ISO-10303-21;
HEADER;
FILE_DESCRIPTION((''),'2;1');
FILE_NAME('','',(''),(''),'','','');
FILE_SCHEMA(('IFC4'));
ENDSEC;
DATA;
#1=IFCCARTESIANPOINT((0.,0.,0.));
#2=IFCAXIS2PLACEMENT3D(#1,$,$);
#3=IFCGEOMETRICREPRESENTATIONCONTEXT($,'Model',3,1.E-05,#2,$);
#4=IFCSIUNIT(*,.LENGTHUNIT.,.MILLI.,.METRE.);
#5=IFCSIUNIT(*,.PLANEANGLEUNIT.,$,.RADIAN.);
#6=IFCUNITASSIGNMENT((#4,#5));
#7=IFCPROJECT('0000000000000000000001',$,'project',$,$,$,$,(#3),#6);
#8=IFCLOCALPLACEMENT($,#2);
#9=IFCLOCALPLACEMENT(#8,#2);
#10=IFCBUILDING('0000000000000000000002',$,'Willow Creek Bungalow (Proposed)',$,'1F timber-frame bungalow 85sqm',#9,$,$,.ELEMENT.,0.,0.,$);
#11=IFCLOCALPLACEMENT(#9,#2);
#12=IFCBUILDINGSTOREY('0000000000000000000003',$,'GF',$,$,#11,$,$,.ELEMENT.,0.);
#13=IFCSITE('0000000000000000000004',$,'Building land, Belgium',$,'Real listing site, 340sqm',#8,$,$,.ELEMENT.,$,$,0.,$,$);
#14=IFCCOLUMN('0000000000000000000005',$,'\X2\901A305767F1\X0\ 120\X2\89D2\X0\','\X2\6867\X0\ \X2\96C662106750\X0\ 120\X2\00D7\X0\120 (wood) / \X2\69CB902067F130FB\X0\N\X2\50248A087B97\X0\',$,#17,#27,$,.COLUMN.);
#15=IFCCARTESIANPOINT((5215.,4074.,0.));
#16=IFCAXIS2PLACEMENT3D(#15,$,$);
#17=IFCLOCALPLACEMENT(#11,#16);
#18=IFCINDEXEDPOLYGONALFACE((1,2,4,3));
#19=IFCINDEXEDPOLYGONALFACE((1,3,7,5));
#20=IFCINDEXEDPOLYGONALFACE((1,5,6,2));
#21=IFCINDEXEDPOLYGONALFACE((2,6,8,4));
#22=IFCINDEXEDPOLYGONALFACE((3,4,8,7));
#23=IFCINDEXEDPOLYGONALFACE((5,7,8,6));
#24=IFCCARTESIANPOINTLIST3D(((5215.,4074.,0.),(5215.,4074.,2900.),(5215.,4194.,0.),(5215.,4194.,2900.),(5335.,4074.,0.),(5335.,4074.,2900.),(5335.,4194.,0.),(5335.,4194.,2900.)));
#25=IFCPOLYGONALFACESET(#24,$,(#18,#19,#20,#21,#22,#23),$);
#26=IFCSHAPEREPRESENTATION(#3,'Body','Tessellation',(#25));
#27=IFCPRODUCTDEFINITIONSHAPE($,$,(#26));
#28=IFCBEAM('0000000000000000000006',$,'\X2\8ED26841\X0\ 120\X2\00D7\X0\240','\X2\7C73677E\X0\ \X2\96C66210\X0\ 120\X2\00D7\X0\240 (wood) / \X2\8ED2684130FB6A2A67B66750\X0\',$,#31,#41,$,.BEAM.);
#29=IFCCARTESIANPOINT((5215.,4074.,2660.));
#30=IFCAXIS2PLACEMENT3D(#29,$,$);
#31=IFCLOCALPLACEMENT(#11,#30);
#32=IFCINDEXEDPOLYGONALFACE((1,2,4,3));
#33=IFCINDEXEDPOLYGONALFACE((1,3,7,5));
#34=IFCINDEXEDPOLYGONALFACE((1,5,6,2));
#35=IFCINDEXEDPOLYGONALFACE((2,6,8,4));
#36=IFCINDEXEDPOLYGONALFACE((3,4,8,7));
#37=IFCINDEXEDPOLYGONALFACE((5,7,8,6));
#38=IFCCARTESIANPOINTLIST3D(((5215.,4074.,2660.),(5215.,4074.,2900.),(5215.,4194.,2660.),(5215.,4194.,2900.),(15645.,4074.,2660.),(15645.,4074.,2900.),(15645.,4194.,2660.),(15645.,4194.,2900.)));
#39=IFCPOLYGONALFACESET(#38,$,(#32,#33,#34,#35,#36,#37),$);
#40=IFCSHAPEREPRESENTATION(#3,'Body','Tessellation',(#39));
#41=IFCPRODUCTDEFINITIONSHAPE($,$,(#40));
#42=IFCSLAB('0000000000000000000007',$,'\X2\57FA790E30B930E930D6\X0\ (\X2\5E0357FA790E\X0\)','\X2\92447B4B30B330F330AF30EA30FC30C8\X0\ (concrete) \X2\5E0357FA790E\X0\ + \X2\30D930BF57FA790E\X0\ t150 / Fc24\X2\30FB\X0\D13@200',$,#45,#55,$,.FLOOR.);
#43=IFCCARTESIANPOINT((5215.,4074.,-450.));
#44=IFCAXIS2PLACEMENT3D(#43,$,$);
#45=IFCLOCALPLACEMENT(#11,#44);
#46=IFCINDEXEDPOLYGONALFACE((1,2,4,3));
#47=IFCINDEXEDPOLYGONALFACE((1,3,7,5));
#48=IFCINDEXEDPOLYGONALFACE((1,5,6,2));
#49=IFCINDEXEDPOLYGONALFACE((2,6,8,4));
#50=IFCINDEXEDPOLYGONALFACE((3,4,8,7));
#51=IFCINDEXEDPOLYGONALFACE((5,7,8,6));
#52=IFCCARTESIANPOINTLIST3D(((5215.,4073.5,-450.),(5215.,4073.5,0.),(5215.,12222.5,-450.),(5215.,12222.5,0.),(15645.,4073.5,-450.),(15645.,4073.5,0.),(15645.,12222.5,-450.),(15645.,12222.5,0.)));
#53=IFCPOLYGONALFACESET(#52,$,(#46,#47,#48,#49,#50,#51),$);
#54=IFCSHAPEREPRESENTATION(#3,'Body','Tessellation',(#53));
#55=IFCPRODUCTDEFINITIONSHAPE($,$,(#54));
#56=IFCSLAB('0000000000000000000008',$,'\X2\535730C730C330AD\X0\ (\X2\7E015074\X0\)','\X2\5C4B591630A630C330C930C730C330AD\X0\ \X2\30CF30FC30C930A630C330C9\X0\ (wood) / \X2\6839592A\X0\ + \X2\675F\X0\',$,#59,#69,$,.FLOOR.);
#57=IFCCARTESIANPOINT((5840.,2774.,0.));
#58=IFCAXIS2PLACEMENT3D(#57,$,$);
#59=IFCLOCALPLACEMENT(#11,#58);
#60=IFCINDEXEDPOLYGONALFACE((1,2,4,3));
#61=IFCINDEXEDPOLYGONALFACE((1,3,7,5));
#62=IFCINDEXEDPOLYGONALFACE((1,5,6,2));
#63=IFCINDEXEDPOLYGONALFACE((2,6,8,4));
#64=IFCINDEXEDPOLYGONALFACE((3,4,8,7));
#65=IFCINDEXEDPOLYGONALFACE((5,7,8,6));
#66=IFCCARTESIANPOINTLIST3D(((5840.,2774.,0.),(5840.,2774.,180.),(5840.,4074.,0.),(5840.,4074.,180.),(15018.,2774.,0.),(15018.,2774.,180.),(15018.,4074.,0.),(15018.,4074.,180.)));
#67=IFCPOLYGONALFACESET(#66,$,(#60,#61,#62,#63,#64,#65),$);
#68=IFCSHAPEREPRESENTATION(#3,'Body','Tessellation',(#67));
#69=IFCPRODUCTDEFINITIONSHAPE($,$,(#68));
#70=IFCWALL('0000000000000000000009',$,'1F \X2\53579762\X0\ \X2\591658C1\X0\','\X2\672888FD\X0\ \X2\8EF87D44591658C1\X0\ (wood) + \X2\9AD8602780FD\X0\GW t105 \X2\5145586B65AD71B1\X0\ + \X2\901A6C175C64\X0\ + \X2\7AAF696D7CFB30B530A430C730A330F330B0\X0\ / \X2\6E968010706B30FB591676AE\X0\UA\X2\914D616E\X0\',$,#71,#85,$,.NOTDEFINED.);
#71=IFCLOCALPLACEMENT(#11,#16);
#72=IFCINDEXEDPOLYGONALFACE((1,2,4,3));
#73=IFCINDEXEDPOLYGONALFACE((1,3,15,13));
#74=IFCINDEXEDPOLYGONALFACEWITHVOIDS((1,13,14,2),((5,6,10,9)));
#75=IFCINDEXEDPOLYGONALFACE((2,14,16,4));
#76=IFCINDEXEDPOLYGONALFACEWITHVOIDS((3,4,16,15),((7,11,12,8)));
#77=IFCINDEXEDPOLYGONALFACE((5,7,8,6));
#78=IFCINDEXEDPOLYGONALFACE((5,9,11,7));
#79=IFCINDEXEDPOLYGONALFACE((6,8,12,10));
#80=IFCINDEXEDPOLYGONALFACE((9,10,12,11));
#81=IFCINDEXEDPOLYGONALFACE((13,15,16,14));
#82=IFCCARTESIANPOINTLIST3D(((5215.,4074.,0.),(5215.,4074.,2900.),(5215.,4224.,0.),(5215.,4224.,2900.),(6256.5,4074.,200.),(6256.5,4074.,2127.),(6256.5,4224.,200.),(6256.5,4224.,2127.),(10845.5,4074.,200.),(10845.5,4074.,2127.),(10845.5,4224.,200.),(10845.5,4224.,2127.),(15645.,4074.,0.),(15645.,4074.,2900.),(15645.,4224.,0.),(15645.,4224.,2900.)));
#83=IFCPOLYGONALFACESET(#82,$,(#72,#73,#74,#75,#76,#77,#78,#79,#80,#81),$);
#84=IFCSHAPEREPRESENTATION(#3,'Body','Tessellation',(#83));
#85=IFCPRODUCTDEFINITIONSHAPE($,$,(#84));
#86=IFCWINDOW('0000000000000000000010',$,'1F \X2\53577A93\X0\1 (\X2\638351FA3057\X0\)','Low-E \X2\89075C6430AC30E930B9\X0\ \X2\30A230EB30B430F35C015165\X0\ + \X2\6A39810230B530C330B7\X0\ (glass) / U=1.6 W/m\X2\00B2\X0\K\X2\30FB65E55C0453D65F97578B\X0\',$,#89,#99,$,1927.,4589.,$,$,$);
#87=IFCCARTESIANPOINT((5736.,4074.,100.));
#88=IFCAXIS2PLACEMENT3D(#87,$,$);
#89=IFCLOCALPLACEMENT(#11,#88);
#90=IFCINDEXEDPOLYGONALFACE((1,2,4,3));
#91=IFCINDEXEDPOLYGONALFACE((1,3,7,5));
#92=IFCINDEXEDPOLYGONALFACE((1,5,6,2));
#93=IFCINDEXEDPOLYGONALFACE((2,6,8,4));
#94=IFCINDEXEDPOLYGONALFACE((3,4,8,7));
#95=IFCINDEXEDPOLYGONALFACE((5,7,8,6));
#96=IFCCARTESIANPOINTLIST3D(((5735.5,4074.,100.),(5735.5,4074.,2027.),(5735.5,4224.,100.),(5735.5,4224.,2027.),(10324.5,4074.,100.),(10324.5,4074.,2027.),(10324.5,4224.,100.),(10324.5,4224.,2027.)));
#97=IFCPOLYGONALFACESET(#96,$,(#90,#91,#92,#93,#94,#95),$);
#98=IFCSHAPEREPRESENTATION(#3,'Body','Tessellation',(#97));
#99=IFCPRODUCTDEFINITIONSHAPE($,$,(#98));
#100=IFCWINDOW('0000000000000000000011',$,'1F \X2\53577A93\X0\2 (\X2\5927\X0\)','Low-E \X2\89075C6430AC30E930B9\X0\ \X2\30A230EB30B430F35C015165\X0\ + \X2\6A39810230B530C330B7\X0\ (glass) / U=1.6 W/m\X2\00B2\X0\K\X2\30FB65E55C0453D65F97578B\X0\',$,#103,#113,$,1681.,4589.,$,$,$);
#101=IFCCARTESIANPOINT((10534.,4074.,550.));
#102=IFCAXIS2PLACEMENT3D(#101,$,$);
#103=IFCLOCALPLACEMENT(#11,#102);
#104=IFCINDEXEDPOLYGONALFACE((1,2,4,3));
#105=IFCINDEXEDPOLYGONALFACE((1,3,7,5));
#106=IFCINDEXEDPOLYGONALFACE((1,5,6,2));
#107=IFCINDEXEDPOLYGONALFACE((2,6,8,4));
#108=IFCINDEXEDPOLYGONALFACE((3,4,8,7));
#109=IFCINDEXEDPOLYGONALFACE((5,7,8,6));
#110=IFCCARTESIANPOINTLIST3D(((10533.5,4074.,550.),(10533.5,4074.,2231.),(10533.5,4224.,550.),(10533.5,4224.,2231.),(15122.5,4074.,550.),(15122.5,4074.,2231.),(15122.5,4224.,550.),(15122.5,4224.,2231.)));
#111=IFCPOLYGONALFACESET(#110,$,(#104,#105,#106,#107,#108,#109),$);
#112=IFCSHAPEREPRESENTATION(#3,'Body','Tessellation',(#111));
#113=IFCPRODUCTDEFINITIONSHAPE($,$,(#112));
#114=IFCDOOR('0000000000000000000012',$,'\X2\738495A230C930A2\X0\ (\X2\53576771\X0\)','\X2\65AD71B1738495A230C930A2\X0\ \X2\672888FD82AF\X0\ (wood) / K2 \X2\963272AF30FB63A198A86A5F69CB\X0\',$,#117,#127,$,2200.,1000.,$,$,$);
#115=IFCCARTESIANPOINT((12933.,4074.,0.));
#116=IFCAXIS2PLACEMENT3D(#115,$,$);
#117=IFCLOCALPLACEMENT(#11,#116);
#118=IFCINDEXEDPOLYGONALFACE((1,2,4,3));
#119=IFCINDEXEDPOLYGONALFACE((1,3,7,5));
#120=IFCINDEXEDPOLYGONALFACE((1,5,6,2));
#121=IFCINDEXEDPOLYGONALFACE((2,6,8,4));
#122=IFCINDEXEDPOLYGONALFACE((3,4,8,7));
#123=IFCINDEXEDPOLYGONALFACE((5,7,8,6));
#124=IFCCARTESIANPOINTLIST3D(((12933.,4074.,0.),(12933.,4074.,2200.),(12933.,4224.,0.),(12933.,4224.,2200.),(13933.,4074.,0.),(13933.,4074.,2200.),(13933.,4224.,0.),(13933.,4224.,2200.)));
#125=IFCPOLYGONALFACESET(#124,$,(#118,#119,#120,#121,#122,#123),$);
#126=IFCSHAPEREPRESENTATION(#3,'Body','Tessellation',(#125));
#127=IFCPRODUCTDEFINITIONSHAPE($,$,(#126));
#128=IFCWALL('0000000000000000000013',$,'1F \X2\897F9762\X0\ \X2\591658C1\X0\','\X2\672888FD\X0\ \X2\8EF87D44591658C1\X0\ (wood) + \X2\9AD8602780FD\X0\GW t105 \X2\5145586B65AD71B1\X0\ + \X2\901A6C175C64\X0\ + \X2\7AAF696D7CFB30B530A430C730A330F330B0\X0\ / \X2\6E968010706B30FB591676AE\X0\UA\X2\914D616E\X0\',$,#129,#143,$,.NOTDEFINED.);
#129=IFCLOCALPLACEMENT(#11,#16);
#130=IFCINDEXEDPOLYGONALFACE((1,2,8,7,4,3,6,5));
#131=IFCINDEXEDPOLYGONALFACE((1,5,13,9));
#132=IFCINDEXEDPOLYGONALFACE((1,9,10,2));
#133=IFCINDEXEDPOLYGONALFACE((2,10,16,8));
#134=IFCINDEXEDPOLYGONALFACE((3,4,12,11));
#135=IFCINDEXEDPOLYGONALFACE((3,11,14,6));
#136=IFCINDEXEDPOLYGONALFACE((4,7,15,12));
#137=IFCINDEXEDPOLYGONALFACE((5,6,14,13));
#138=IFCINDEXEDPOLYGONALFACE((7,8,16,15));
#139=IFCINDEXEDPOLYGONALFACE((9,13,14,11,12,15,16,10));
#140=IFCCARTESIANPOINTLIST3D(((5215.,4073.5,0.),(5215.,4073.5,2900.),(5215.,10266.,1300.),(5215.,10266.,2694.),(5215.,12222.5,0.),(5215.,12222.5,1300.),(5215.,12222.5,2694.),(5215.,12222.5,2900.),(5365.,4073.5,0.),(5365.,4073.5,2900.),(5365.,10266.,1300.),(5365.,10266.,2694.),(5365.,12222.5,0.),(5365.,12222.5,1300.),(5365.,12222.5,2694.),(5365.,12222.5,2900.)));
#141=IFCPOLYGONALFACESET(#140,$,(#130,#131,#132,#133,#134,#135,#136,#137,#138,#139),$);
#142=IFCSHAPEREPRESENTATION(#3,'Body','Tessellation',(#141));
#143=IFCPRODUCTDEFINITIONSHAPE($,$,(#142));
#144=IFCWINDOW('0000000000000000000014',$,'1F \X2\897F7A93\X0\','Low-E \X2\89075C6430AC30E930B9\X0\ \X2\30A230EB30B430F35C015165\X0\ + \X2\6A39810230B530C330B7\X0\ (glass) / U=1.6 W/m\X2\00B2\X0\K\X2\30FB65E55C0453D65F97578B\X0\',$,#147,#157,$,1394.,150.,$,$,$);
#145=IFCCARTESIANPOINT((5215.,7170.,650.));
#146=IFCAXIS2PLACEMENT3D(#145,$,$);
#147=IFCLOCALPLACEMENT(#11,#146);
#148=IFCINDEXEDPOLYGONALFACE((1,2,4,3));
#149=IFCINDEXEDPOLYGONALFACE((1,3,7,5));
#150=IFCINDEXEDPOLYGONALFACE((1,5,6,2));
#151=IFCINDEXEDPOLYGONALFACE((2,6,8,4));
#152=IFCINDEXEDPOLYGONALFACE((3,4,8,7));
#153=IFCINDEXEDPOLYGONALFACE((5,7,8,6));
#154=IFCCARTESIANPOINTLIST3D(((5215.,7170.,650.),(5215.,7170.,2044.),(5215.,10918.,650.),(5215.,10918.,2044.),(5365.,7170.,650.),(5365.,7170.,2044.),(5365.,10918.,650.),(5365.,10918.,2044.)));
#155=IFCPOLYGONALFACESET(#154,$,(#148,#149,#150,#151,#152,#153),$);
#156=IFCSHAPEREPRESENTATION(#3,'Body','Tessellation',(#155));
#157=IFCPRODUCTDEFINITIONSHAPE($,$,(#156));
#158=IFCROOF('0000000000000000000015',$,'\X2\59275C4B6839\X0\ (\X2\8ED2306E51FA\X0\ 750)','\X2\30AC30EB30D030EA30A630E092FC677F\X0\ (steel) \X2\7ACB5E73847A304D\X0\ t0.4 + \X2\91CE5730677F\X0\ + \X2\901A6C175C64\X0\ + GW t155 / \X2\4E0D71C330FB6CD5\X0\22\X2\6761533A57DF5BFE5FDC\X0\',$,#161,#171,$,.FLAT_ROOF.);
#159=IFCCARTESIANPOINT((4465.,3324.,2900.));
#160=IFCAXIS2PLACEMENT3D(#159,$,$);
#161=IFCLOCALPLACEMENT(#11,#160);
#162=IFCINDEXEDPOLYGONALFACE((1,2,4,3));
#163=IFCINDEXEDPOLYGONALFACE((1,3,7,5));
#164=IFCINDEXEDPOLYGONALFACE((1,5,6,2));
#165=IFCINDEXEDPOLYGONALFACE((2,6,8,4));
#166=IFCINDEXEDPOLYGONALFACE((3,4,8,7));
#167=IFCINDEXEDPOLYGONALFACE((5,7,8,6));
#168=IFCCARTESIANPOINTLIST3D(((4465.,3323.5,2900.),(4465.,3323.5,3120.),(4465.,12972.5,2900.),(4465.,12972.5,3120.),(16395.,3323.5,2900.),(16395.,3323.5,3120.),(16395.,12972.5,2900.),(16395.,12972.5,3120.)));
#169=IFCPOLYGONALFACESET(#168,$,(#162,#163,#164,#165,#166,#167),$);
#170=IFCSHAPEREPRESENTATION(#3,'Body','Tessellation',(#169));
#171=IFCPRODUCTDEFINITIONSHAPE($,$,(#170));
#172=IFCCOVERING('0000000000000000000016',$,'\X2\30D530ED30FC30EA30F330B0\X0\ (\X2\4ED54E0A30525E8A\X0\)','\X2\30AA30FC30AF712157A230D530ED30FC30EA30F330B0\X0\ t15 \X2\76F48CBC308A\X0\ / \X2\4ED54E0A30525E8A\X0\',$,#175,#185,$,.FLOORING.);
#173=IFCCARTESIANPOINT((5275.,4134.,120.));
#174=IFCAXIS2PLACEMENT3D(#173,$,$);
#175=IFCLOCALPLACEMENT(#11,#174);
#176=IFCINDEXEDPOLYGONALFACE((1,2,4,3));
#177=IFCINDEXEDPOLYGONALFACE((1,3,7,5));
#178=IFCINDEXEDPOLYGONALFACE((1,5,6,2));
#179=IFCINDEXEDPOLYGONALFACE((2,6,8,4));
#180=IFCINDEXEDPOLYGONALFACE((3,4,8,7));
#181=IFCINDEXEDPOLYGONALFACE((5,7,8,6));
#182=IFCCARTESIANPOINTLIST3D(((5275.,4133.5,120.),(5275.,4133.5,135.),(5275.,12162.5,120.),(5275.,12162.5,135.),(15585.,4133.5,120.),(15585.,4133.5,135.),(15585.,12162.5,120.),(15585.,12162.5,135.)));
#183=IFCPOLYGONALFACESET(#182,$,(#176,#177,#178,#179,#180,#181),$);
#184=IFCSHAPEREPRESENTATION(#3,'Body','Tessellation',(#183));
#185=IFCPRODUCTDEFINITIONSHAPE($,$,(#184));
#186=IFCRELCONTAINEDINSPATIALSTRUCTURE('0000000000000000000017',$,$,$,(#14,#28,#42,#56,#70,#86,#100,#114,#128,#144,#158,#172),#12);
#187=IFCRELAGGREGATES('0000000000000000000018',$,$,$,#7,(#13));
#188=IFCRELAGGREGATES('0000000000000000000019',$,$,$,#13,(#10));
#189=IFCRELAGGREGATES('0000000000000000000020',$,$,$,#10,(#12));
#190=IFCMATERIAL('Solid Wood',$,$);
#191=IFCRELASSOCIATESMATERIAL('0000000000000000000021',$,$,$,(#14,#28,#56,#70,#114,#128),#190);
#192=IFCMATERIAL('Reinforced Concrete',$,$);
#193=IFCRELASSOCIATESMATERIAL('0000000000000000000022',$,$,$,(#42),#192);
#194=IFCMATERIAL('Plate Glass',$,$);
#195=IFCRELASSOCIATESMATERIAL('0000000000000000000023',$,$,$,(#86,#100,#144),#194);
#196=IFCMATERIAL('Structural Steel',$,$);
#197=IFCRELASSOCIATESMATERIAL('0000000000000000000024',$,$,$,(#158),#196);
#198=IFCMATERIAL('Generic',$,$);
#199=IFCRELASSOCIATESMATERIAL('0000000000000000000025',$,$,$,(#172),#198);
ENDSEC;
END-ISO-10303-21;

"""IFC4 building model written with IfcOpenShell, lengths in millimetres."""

from ifc_helpers import new_model, si_unit, frame, frame_2d, origin, place, context, project, spatial, rectangle, extrude, material, element, fill, save


model = new_model("IFC4")

# Units and contexts
model_context = context("Model", 3, precision=1e-05, world=origin())
ifc_project = project(units=[si_unit("LENGTHUNIT", "METRE", prefix="MILLI"), si_unit("PLANEANGLEUNIT", "RADIAN")], contexts=[model_context])

# Site, building, storey
site_placement = place(None, origin())
site = spatial("IfcSite", under=ifc_project, at=site_placement, Name="Building land, Belgium", ObjectType="Real listing site, 340sqm", CompositionType="ELEMENT", RefElevation=0.0)
building_placement = place(site_placement, origin())
building = spatial("IfcBuilding", under=site, at=building_placement, Name="Willow Creek Bungalow (Proposed)", ObjectType="1F timber-frame bungalow 85sqm", CompositionType="ELEMENT", ElevationOfRefHeight=0.0, ElevationOfTerrain=0.0)
storey_placement = place(building_placement, origin())
storey = spatial("IfcBuildingStorey", under=building, at=storey_placement, Name="GF", CompositionType="ELEMENT", Elevation=0.0)

# Column
ifc_material_1 = material(Name="Solid Wood")
column_1_placement = place(storey_placement, frame((5215.0, 4074.0, 0.0)))
element("IfcColumn", 1, at=column_1_placement, inside=storey, material=ifc_material_1, Name="通し柱 120角", Description="桧 集成材 120×120 (wood) / 構造柱・N値計算", PredefinedType="COLUMN", context=model_context, shape_type="SweptSolid", body=[
    extrude(rectangle(XDim=120.0, YDim=120.0, at=frame_2d((60.0, 60.0))), frame((5215.0, 4074.0, 0.0)), (0.0, 0.0, 1.0), 2900.0),
])

# Beam
beam_1_placement = place(storey_placement, frame((5215.0, 4074.0, 2660.0)))
element("IfcBeam", 2, at=beam_1_placement, inside=storey, material=ifc_material_1, Name="軒桁 120×240", Description="米松 集成 120×240 (wood) / 軒桁・横架材", PredefinedType="BEAM", context=model_context, shape_type="SweptSolid", body=[
    extrude(rectangle(XDim=10430.0, YDim=120.0, at=frame_2d((5215.0, 60.0))), frame((5215.0, 4074.0, 2660.0)), (0.0, 0.0, 1.0), 240.0),
])

# Slabs
ifc_material_2 = material(Name="Reinforced Concrete")
slab_1_placement = place(storey_placement, frame((5215.0, 4074.0, -450.0)))
element("IfcSlab", 3, at=slab_1_placement, inside=storey, material=ifc_material_2, Name="基礎スラブ (布基礎)", Description="鉄筋コンクリート (concrete) 布基礎 + ベタ基礎 t150 / Fc24・D13@200", PredefinedType="FLOOR", context=model_context, shape_type="SweptSolid", body=[
    extrude(rectangle(XDim=10430.0, YDim=8149.0, at=frame_2d((5215.0, 4074.0))), frame((5215.0, 4074.0, -450.0)), (0.0, 0.0, 1.0), 450.0),
])
slab_2_placement = place(storey_placement, frame((5840.0, 2774.0, 0.0)))
element("IfcSlab", 4, at=slab_2_placement, inside=storey, material=ifc_material_1, Name="南デッキ (縁側)", Description="屋外ウッドデッキ ハードウッド (wood) / 根太 + 束", PredefinedType="FLOOR", context=model_context, shape_type="SweptSolid", body=[
    extrude(rectangle(XDim=9178.0, YDim=1300.0, at=frame_2d((4589.0, 650.0))), frame((5840.0, 2774.0, 0.0)), (0.0, 0.0, 1.0), 180.0),
])

# Wall, openings, windows, door
wall_1_placement = place(storey_placement, frame((5215.0, 4074.0, 0.0)))
wall_1 = element("IfcWall", 5, at=wall_1_placement, inside=storey, material=ifc_material_1, Name="1F 南面 外壁", Description="木製 軸組外壁 (wood) + 高性能GW t105 充填断熱 + 通気層 + 窯業系サイディング / 準耐火・外皮UA配慮", PredefinedType="NOTDEFINED", context=model_context, shape_type="SweptSolid", body=[
    extrude(rectangle(XDim=10430.0, YDim=150.0, at=frame_2d((5215.0, 75.0))), frame((5215.0, 4074.0, 0.0)), (0.0, 0.0, 1.0), 2900.0),
])
opening_1_placement = place(storey_placement, frame((5736.0, 4074.0, 100.0)))
opening_1 = element("IfcOpeningElement", 6, at=opening_1_placement, cuts=wall_1, PredefinedType="NOTDEFINED", context=model_context, shape_type="SweptSolid", body=[
    extrude(rectangle(XDim=4589.0, YDim=150.0, at=frame_2d((2294.0, 75.0))), frame((5736.0, 4074.0, 100.0)), (0.0, 0.0, 1.0), 1927.0),
])
opening_2_placement = place(storey_placement, frame((10534.0, 4074.0, 550.0)))
opening_2 = element("IfcOpeningElement", 7, at=opening_2_placement, cuts=wall_1, PredefinedType="NOTDEFINED", context=model_context, shape_type="SweptSolid", body=[
    extrude(rectangle(XDim=4589.0, YDim=150.0, at=frame_2d((2294.0, 75.0))), frame((10534.0, 4074.0, 550.0)), (0.0, 0.0, 1.0), 1681.0),
])
opening_3_placement = place(storey_placement, frame((12933.0, 4074.0, 0.0)))
opening_3 = element("IfcOpeningElement", 8, at=opening_3_placement, cuts=wall_1, PredefinedType="NOTDEFINED", context=model_context, shape_type="SweptSolid", body=[
    extrude(rectangle(XDim=1000.0, YDim=150.0, at=frame_2d((500.0, 75.0))), frame((12933.0, 4074.0, 0.0)), (0.0, 0.0, 1.0), 2200.0),
])
ifc_material_3 = material(Name="Plate Glass")
window_1_placement = place(storey_placement, frame((5736.0, 4074.0, 100.0)))
window_1 = element("IfcWindow", 9, at=window_1_placement, inside=storey, material=ifc_material_3, Name="1F 南窓1 (掃出し)", Description="Low-E 複層ガラス アルゴン封入 + 樹脂サッシ (glass) / U=1.6 W/m²K・日射取得型", OverallHeight=1927.0, OverallWidth=4589.0, context=model_context, shape_type="SweptSolid", body=[
    extrude(rectangle(XDim=4589.0, YDim=150.0, at=frame_2d((2294.0, 75.0))), frame((5736.0, 4074.0, 100.0)), (0.0, 0.0, 1.0), 1927.0),
])
fill(opening_1, window_1)
window_2_placement = place(storey_placement, frame((10534.0, 4074.0, 550.0)))
window_2 = element("IfcWindow", 10, at=window_2_placement, inside=storey, material=ifc_material_3, Name="1F 南窓2 (大)", Description="Low-E 複層ガラス アルゴン封入 + 樹脂サッシ (glass) / U=1.6 W/m²K・日射取得型", OverallHeight=1681.0, OverallWidth=4589.0, context=model_context, shape_type="SweptSolid", body=[
    extrude(rectangle(XDim=4589.0, YDim=150.0, at=frame_2d((2294.0, 75.0))), frame((10534.0, 4074.0, 550.0)), (0.0, 0.0, 1.0), 1681.0),
])
fill(opening_2, window_2)
door_placement = place(storey_placement, frame((12933.0, 4074.0, 0.0)))
door = element("IfcDoor", 11, at=door_placement, inside=storey, material=ifc_material_1, Name="玄関ドア (南東)", Description="断熱玄関ドア 木製芯 (wood) / K2 防犯・採風機構", OverallHeight=2200.0, OverallWidth=1000.0, context=model_context, shape_type="SweptSolid", body=[
    extrude(rectangle(XDim=1000.0, YDim=150.0, at=frame_2d((500.0, 75.0))), frame((12933.0, 4074.0, 0.0)), (0.0, 0.0, 1.0), 2200.0),
])
fill(opening_3, door)

# Wall, opening, window
wall_2_placement = place(storey_placement, frame((5215.0, 4074.0, 0.0)))
wall_2 = element("IfcWall", 12, at=wall_2_placement, inside=storey, material=ifc_material_1, Name="1F 西面 外壁", Description="木製 軸組外壁 (wood) + 高性能GW t105 充填断熱 + 通気層 + 窯業系サイディング / 準耐火・外皮UA配慮", PredefinedType="NOTDEFINED", context=model_context, shape_type="SweptSolid", body=[
    extrude(rectangle(XDim=150.0, YDim=8149.0, at=frame_2d((75.0, 4074.0))), frame((5215.0, 4074.0, 0.0)), (0.0, 0.0, 1.0), 2900.0),
])
opening_4_placement = place(storey_placement, frame((5215.0, 7170.0, 650.0)))
opening_4 = element("IfcOpeningElement", 13, at=opening_4_placement, cuts=wall_2, PredefinedType="NOTDEFINED", context=model_context, shape_type="SweptSolid", body=[
    extrude(rectangle(XDim=150.0, YDim=3748.0, at=frame_2d((75.0, 1874.0))), frame((5215.0, 7170.0, 650.0)), (0.0, 0.0, 1.0), 1394.0),
])
window_3_placement = place(storey_placement, frame((5215.0, 7170.0, 650.0)))
window_3 = element("IfcWindow", 14, at=window_3_placement, inside=storey, material=ifc_material_3, Name="1F 西窓", Description="Low-E 複層ガラス アルゴン封入 + 樹脂サッシ (glass) / U=1.6 W/m²K・日射取得型", OverallHeight=1394.0, OverallWidth=150.0, context=model_context, shape_type="SweptSolid", body=[
    extrude(rectangle(XDim=150.0, YDim=3748.0, at=frame_2d((75.0, 1874.0))), frame((5215.0, 7170.0, 650.0)), (0.0, 0.0, 1.0), 1394.0),
])
fill(opening_4, window_3)

# Roof
ifc_material_4 = material(Name="Structural Steel")
roof_placement = place(storey_placement, frame((4465.0, 3324.0, 2900.0)))
element("IfcRoof", 15, at=roof_placement, inside=storey, material=ifc_material_4, Name="大屋根 (軒の出 750)", Description="ガルバリウム鋼板 (steel) 立平葺き t0.4 + 野地板 + 通気層 + GW t155 / 不燃・法22条区域対応", PredefinedType="FLAT_ROOF", context=model_context, shape_type="SweptSolid", body=[
    extrude(rectangle(XDim=11930.0, YDim=9649.0, at=frame_2d((5965.0, 4824.0))), frame((4465.0, 3324.0, 2900.0)), (0.0, 0.0, 1.0), 220.0),
])

# Covering
ifc_material_5 = material(Name="Generic")
covering_1_placement = place(storey_placement, frame((5275.0, 4134.0, 120.0)))
element("IfcCovering", 16, at=covering_1_placement, inside=storey, material=ifc_material_5, Name="フローリング (仕上げ床)", Description="オーク無垢フローリング t15 直貼り / 仕上げ床", PredefinedType="FLOORING", context=model_context, shape_type="SweptSolid", body=[
    extrude(rectangle(XDim=10310.0, YDim=8029.0, at=frame_2d((5155.0, 4014.0))), frame((5275.0, 4134.0, 120.0)), (0.0, 0.0, 1.0), 15.0),
])

save(model, "model.ifc")
